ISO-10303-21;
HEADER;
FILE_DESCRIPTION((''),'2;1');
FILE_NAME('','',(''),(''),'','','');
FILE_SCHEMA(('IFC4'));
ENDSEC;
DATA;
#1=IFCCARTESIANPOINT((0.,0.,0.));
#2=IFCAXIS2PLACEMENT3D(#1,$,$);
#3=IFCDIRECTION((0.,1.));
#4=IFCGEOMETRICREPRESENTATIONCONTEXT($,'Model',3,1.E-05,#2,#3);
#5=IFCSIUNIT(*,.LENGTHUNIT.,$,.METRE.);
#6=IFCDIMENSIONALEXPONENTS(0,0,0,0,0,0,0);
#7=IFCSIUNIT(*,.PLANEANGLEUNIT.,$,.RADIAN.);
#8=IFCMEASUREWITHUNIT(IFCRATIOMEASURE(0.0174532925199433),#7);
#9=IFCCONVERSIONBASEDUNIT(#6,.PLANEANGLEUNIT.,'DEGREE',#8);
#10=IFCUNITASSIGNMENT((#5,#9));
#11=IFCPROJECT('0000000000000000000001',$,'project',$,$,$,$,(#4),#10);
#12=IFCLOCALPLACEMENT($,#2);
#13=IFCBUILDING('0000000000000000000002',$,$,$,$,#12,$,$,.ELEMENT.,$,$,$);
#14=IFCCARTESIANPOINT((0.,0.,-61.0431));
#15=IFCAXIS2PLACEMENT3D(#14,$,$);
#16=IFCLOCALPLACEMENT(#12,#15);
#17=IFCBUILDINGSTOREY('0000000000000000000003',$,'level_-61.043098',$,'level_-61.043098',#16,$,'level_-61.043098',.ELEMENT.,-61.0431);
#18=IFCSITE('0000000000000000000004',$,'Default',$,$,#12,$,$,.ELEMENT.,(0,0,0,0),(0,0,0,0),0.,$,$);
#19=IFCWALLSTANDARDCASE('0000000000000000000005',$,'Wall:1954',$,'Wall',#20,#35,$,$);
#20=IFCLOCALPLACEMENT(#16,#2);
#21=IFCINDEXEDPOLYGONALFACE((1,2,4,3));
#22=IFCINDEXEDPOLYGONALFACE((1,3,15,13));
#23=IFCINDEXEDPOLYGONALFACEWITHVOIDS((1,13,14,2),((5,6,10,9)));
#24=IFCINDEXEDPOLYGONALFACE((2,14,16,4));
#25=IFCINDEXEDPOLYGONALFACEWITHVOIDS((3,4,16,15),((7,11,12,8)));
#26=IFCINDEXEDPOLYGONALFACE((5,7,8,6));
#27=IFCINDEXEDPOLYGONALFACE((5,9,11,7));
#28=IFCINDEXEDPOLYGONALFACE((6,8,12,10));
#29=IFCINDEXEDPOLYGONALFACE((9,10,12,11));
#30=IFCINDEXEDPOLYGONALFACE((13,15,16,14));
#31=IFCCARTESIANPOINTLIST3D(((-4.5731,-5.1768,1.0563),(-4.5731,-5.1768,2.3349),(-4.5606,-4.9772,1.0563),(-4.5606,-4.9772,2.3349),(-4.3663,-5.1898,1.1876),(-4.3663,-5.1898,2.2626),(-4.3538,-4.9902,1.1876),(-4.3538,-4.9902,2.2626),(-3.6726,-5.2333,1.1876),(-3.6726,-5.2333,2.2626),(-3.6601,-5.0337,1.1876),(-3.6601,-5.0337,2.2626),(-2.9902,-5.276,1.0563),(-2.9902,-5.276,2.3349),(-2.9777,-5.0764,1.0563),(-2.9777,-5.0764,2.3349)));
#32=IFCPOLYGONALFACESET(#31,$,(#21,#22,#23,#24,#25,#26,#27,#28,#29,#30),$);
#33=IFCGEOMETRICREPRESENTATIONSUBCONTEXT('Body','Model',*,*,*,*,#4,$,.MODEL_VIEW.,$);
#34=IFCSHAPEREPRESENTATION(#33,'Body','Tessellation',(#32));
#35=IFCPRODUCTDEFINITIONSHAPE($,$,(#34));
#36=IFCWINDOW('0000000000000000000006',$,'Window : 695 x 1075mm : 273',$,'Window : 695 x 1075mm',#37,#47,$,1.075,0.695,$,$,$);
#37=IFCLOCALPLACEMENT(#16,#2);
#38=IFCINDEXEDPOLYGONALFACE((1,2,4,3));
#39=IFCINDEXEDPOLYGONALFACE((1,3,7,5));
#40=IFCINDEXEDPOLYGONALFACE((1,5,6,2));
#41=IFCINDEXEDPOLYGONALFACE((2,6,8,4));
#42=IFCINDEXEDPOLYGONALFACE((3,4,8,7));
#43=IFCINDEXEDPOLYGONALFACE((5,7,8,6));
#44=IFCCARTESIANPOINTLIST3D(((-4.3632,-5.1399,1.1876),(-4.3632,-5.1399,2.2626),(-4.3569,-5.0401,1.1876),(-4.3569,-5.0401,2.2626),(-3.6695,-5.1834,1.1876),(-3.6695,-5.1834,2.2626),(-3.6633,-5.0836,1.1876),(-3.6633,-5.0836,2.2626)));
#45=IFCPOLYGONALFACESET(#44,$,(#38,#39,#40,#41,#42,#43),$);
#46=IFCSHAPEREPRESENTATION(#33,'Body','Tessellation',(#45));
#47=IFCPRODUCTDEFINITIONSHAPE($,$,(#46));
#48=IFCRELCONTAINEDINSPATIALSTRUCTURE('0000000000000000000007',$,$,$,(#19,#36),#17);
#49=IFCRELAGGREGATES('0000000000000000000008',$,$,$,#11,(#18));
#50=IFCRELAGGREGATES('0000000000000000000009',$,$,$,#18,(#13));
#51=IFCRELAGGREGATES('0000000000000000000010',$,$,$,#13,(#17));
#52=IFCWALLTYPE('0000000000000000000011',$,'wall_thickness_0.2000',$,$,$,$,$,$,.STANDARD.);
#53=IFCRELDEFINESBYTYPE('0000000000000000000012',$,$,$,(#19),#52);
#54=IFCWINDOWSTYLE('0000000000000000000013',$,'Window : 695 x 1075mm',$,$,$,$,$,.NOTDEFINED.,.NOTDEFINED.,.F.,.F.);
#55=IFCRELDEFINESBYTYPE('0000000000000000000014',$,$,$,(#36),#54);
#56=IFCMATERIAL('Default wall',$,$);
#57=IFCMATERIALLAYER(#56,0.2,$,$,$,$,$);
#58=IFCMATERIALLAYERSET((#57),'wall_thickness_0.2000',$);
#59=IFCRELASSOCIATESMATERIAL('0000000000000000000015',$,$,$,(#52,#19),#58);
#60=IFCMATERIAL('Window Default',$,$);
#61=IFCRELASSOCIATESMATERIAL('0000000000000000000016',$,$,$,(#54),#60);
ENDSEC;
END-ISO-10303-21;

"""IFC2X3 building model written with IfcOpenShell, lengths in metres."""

from ifc_helpers import new_model, entity, si_unit, converted_unit, direction, frame, frame_2d, origin, origin_2d_with_axis, place, context, subcontext, project, spatial, polyline, rectangle, outline, extrude, source, transform, mapped, material, layer, layer_set, layer_usage, type_object, type_shapes, element, fill, save


model = new_model("IFC2X3")

# Units and contexts
model_context = context("Model", 3, precision=1e-05, world=origin(), true_north=direction((0.0, 1.0)))
body_context = subcontext(model_context, "Body", "Model", "MODEL_VIEW")
ifc_project = project(units=[si_unit("LENGTHUNIT", "METRE"), converted_unit("PLANEANGLEUNIT", "DEGREE", entity("IfcRatioMeasure", 0.0174532925199433), si_unit("PLANEANGLEUNIT", "RADIAN"), dimensions=[0, 0, 0, 0, 0, 0, 0])], contexts=[model_context])

# Site, building, storey
placement_1 = place(None, origin())
site = spatial("IfcSite", under=ifc_project, at=placement_1, Name="Default", CompositionType="ELEMENT", RefLatitude=(0, 0, 0, 0), RefLongitude=(0, 0, 0, 0), RefElevation=0.0)
building = spatial("IfcBuilding", under=site, at=placement_1, CompositionType="ELEMENT")
storey_placement = place(placement_1, frame((0.0, 0.0, -61.0431)))
storey = spatial("IfcBuildingStorey", under=building, at=storey_placement, Name="level_-61.043098", ObjectType="level_-61.043098", LongName="level_-61.043098", CompositionType="ELEMENT", Elevation=-61.0431)

# Shared definitions
ifc_material_1 = material(Name="Default wall")
ifc_layer = layer(ifc_material_1, 0.2)
ifc_layer_set = layer_set([ifc_layer], Name="wall_thickness_0.2000")
ifc_layer_usage = layer_usage(ifc_layer_set, "AXIS2", "POSITIVE", -0.1)
wall_type = type_object("IfcWallType", Name="wall_thickness_0.2000", PredefinedType="STANDARD", material=ifc_layer_set)

# Shared definitions
ifc_material_2 = material(Name="Window Default")

# Wall, opening, window
placement_2 = place(placement_1, frame((0.0, 0.0, -59.9868)))
wall_1_placement = place(placement_2, frame((-2.984, -5.1762, 0.0), z_axis=(0.0, 0.0, 1.0), x_axis=(-0.998041, 0.062565, 0.0)))
wall_1 = element("IfcWallStandardCase", 1, at=wall_1_placement, inside=storey, type_object=wall_type, material=ifc_layer_usage, Name="Wall:1954", ObjectType="Wall", context=body_context, shape_type="SweptSolid", body=[
    extrude(outline(polyline([(1.586, -0.1), (1.586, 0.1), (0.0, 0.1), (0.0, -0.1), (1.586, -0.1)])), origin(), (0.0, 0.0, 1.0), 1.2785),
])
opening_1_placement = place(wall_1_placement, frame((0.6837, -0.1, 0.1312)))
opening_1 = element("IfcOpeningElement", 2, at=opening_1_placement, cuts=wall_1, ObjectType="Opening", context=body_context, shape_type="SweptSolid", body=[
    extrude(rectangle(XDim=0.695, YDim=1.075, at=frame_2d((0.5375, 0.3475), x_axis=(0.0, 1.0))), frame((0.0, 0.0, 0.0), z_axis=(0.0, 1.0, 0.0), x_axis=(0.0, 0.0, 1.0)), (0.0, 0.0, 1.0), 0.2),
])
window_style_1 = type_object("IfcWindowStyle", Name="Window : 695 x 1075mm", ConstructionType="NOTDEFINED", OperationType="NOTDEFINED", ParameterTakesPrecedence=False, Sizeable=False, material=ifc_material_2)
shared_shape_1 = source(origin(), body_context, "Body", "SweptSolid", [
    extrude(rectangle(XDim=0.1, YDim=0.695, at=origin_2d_with_axis()), frame((0.3475, 0.1, 0.0), z_axis=(0.0, 0.0, 1.0), x_axis=(0.0, 1.0, 0.0)), (0.0, 0.0, 1.0), 1.075),
])
type_shapes(window_style_1, [shared_shape_1])
window_1_placement = place(opening_1_placement, origin())
window_1 = element("IfcWindow", 3, at=window_1_placement, inside=storey, type_object=window_style_1, Name="Window : 695 x 1075mm : 273", ObjectType="Window : 695 x 1075mm", OverallHeight=1.075, OverallWidth=0.695, context=body_context, shape_type="MappedRepresentation", body=[
    mapped(shared_shape_1, transform((0.0, 0.0, 0.0), scale=1.0)),
])
fill(opening_1, window_1)

save(model, "model.ifc")
